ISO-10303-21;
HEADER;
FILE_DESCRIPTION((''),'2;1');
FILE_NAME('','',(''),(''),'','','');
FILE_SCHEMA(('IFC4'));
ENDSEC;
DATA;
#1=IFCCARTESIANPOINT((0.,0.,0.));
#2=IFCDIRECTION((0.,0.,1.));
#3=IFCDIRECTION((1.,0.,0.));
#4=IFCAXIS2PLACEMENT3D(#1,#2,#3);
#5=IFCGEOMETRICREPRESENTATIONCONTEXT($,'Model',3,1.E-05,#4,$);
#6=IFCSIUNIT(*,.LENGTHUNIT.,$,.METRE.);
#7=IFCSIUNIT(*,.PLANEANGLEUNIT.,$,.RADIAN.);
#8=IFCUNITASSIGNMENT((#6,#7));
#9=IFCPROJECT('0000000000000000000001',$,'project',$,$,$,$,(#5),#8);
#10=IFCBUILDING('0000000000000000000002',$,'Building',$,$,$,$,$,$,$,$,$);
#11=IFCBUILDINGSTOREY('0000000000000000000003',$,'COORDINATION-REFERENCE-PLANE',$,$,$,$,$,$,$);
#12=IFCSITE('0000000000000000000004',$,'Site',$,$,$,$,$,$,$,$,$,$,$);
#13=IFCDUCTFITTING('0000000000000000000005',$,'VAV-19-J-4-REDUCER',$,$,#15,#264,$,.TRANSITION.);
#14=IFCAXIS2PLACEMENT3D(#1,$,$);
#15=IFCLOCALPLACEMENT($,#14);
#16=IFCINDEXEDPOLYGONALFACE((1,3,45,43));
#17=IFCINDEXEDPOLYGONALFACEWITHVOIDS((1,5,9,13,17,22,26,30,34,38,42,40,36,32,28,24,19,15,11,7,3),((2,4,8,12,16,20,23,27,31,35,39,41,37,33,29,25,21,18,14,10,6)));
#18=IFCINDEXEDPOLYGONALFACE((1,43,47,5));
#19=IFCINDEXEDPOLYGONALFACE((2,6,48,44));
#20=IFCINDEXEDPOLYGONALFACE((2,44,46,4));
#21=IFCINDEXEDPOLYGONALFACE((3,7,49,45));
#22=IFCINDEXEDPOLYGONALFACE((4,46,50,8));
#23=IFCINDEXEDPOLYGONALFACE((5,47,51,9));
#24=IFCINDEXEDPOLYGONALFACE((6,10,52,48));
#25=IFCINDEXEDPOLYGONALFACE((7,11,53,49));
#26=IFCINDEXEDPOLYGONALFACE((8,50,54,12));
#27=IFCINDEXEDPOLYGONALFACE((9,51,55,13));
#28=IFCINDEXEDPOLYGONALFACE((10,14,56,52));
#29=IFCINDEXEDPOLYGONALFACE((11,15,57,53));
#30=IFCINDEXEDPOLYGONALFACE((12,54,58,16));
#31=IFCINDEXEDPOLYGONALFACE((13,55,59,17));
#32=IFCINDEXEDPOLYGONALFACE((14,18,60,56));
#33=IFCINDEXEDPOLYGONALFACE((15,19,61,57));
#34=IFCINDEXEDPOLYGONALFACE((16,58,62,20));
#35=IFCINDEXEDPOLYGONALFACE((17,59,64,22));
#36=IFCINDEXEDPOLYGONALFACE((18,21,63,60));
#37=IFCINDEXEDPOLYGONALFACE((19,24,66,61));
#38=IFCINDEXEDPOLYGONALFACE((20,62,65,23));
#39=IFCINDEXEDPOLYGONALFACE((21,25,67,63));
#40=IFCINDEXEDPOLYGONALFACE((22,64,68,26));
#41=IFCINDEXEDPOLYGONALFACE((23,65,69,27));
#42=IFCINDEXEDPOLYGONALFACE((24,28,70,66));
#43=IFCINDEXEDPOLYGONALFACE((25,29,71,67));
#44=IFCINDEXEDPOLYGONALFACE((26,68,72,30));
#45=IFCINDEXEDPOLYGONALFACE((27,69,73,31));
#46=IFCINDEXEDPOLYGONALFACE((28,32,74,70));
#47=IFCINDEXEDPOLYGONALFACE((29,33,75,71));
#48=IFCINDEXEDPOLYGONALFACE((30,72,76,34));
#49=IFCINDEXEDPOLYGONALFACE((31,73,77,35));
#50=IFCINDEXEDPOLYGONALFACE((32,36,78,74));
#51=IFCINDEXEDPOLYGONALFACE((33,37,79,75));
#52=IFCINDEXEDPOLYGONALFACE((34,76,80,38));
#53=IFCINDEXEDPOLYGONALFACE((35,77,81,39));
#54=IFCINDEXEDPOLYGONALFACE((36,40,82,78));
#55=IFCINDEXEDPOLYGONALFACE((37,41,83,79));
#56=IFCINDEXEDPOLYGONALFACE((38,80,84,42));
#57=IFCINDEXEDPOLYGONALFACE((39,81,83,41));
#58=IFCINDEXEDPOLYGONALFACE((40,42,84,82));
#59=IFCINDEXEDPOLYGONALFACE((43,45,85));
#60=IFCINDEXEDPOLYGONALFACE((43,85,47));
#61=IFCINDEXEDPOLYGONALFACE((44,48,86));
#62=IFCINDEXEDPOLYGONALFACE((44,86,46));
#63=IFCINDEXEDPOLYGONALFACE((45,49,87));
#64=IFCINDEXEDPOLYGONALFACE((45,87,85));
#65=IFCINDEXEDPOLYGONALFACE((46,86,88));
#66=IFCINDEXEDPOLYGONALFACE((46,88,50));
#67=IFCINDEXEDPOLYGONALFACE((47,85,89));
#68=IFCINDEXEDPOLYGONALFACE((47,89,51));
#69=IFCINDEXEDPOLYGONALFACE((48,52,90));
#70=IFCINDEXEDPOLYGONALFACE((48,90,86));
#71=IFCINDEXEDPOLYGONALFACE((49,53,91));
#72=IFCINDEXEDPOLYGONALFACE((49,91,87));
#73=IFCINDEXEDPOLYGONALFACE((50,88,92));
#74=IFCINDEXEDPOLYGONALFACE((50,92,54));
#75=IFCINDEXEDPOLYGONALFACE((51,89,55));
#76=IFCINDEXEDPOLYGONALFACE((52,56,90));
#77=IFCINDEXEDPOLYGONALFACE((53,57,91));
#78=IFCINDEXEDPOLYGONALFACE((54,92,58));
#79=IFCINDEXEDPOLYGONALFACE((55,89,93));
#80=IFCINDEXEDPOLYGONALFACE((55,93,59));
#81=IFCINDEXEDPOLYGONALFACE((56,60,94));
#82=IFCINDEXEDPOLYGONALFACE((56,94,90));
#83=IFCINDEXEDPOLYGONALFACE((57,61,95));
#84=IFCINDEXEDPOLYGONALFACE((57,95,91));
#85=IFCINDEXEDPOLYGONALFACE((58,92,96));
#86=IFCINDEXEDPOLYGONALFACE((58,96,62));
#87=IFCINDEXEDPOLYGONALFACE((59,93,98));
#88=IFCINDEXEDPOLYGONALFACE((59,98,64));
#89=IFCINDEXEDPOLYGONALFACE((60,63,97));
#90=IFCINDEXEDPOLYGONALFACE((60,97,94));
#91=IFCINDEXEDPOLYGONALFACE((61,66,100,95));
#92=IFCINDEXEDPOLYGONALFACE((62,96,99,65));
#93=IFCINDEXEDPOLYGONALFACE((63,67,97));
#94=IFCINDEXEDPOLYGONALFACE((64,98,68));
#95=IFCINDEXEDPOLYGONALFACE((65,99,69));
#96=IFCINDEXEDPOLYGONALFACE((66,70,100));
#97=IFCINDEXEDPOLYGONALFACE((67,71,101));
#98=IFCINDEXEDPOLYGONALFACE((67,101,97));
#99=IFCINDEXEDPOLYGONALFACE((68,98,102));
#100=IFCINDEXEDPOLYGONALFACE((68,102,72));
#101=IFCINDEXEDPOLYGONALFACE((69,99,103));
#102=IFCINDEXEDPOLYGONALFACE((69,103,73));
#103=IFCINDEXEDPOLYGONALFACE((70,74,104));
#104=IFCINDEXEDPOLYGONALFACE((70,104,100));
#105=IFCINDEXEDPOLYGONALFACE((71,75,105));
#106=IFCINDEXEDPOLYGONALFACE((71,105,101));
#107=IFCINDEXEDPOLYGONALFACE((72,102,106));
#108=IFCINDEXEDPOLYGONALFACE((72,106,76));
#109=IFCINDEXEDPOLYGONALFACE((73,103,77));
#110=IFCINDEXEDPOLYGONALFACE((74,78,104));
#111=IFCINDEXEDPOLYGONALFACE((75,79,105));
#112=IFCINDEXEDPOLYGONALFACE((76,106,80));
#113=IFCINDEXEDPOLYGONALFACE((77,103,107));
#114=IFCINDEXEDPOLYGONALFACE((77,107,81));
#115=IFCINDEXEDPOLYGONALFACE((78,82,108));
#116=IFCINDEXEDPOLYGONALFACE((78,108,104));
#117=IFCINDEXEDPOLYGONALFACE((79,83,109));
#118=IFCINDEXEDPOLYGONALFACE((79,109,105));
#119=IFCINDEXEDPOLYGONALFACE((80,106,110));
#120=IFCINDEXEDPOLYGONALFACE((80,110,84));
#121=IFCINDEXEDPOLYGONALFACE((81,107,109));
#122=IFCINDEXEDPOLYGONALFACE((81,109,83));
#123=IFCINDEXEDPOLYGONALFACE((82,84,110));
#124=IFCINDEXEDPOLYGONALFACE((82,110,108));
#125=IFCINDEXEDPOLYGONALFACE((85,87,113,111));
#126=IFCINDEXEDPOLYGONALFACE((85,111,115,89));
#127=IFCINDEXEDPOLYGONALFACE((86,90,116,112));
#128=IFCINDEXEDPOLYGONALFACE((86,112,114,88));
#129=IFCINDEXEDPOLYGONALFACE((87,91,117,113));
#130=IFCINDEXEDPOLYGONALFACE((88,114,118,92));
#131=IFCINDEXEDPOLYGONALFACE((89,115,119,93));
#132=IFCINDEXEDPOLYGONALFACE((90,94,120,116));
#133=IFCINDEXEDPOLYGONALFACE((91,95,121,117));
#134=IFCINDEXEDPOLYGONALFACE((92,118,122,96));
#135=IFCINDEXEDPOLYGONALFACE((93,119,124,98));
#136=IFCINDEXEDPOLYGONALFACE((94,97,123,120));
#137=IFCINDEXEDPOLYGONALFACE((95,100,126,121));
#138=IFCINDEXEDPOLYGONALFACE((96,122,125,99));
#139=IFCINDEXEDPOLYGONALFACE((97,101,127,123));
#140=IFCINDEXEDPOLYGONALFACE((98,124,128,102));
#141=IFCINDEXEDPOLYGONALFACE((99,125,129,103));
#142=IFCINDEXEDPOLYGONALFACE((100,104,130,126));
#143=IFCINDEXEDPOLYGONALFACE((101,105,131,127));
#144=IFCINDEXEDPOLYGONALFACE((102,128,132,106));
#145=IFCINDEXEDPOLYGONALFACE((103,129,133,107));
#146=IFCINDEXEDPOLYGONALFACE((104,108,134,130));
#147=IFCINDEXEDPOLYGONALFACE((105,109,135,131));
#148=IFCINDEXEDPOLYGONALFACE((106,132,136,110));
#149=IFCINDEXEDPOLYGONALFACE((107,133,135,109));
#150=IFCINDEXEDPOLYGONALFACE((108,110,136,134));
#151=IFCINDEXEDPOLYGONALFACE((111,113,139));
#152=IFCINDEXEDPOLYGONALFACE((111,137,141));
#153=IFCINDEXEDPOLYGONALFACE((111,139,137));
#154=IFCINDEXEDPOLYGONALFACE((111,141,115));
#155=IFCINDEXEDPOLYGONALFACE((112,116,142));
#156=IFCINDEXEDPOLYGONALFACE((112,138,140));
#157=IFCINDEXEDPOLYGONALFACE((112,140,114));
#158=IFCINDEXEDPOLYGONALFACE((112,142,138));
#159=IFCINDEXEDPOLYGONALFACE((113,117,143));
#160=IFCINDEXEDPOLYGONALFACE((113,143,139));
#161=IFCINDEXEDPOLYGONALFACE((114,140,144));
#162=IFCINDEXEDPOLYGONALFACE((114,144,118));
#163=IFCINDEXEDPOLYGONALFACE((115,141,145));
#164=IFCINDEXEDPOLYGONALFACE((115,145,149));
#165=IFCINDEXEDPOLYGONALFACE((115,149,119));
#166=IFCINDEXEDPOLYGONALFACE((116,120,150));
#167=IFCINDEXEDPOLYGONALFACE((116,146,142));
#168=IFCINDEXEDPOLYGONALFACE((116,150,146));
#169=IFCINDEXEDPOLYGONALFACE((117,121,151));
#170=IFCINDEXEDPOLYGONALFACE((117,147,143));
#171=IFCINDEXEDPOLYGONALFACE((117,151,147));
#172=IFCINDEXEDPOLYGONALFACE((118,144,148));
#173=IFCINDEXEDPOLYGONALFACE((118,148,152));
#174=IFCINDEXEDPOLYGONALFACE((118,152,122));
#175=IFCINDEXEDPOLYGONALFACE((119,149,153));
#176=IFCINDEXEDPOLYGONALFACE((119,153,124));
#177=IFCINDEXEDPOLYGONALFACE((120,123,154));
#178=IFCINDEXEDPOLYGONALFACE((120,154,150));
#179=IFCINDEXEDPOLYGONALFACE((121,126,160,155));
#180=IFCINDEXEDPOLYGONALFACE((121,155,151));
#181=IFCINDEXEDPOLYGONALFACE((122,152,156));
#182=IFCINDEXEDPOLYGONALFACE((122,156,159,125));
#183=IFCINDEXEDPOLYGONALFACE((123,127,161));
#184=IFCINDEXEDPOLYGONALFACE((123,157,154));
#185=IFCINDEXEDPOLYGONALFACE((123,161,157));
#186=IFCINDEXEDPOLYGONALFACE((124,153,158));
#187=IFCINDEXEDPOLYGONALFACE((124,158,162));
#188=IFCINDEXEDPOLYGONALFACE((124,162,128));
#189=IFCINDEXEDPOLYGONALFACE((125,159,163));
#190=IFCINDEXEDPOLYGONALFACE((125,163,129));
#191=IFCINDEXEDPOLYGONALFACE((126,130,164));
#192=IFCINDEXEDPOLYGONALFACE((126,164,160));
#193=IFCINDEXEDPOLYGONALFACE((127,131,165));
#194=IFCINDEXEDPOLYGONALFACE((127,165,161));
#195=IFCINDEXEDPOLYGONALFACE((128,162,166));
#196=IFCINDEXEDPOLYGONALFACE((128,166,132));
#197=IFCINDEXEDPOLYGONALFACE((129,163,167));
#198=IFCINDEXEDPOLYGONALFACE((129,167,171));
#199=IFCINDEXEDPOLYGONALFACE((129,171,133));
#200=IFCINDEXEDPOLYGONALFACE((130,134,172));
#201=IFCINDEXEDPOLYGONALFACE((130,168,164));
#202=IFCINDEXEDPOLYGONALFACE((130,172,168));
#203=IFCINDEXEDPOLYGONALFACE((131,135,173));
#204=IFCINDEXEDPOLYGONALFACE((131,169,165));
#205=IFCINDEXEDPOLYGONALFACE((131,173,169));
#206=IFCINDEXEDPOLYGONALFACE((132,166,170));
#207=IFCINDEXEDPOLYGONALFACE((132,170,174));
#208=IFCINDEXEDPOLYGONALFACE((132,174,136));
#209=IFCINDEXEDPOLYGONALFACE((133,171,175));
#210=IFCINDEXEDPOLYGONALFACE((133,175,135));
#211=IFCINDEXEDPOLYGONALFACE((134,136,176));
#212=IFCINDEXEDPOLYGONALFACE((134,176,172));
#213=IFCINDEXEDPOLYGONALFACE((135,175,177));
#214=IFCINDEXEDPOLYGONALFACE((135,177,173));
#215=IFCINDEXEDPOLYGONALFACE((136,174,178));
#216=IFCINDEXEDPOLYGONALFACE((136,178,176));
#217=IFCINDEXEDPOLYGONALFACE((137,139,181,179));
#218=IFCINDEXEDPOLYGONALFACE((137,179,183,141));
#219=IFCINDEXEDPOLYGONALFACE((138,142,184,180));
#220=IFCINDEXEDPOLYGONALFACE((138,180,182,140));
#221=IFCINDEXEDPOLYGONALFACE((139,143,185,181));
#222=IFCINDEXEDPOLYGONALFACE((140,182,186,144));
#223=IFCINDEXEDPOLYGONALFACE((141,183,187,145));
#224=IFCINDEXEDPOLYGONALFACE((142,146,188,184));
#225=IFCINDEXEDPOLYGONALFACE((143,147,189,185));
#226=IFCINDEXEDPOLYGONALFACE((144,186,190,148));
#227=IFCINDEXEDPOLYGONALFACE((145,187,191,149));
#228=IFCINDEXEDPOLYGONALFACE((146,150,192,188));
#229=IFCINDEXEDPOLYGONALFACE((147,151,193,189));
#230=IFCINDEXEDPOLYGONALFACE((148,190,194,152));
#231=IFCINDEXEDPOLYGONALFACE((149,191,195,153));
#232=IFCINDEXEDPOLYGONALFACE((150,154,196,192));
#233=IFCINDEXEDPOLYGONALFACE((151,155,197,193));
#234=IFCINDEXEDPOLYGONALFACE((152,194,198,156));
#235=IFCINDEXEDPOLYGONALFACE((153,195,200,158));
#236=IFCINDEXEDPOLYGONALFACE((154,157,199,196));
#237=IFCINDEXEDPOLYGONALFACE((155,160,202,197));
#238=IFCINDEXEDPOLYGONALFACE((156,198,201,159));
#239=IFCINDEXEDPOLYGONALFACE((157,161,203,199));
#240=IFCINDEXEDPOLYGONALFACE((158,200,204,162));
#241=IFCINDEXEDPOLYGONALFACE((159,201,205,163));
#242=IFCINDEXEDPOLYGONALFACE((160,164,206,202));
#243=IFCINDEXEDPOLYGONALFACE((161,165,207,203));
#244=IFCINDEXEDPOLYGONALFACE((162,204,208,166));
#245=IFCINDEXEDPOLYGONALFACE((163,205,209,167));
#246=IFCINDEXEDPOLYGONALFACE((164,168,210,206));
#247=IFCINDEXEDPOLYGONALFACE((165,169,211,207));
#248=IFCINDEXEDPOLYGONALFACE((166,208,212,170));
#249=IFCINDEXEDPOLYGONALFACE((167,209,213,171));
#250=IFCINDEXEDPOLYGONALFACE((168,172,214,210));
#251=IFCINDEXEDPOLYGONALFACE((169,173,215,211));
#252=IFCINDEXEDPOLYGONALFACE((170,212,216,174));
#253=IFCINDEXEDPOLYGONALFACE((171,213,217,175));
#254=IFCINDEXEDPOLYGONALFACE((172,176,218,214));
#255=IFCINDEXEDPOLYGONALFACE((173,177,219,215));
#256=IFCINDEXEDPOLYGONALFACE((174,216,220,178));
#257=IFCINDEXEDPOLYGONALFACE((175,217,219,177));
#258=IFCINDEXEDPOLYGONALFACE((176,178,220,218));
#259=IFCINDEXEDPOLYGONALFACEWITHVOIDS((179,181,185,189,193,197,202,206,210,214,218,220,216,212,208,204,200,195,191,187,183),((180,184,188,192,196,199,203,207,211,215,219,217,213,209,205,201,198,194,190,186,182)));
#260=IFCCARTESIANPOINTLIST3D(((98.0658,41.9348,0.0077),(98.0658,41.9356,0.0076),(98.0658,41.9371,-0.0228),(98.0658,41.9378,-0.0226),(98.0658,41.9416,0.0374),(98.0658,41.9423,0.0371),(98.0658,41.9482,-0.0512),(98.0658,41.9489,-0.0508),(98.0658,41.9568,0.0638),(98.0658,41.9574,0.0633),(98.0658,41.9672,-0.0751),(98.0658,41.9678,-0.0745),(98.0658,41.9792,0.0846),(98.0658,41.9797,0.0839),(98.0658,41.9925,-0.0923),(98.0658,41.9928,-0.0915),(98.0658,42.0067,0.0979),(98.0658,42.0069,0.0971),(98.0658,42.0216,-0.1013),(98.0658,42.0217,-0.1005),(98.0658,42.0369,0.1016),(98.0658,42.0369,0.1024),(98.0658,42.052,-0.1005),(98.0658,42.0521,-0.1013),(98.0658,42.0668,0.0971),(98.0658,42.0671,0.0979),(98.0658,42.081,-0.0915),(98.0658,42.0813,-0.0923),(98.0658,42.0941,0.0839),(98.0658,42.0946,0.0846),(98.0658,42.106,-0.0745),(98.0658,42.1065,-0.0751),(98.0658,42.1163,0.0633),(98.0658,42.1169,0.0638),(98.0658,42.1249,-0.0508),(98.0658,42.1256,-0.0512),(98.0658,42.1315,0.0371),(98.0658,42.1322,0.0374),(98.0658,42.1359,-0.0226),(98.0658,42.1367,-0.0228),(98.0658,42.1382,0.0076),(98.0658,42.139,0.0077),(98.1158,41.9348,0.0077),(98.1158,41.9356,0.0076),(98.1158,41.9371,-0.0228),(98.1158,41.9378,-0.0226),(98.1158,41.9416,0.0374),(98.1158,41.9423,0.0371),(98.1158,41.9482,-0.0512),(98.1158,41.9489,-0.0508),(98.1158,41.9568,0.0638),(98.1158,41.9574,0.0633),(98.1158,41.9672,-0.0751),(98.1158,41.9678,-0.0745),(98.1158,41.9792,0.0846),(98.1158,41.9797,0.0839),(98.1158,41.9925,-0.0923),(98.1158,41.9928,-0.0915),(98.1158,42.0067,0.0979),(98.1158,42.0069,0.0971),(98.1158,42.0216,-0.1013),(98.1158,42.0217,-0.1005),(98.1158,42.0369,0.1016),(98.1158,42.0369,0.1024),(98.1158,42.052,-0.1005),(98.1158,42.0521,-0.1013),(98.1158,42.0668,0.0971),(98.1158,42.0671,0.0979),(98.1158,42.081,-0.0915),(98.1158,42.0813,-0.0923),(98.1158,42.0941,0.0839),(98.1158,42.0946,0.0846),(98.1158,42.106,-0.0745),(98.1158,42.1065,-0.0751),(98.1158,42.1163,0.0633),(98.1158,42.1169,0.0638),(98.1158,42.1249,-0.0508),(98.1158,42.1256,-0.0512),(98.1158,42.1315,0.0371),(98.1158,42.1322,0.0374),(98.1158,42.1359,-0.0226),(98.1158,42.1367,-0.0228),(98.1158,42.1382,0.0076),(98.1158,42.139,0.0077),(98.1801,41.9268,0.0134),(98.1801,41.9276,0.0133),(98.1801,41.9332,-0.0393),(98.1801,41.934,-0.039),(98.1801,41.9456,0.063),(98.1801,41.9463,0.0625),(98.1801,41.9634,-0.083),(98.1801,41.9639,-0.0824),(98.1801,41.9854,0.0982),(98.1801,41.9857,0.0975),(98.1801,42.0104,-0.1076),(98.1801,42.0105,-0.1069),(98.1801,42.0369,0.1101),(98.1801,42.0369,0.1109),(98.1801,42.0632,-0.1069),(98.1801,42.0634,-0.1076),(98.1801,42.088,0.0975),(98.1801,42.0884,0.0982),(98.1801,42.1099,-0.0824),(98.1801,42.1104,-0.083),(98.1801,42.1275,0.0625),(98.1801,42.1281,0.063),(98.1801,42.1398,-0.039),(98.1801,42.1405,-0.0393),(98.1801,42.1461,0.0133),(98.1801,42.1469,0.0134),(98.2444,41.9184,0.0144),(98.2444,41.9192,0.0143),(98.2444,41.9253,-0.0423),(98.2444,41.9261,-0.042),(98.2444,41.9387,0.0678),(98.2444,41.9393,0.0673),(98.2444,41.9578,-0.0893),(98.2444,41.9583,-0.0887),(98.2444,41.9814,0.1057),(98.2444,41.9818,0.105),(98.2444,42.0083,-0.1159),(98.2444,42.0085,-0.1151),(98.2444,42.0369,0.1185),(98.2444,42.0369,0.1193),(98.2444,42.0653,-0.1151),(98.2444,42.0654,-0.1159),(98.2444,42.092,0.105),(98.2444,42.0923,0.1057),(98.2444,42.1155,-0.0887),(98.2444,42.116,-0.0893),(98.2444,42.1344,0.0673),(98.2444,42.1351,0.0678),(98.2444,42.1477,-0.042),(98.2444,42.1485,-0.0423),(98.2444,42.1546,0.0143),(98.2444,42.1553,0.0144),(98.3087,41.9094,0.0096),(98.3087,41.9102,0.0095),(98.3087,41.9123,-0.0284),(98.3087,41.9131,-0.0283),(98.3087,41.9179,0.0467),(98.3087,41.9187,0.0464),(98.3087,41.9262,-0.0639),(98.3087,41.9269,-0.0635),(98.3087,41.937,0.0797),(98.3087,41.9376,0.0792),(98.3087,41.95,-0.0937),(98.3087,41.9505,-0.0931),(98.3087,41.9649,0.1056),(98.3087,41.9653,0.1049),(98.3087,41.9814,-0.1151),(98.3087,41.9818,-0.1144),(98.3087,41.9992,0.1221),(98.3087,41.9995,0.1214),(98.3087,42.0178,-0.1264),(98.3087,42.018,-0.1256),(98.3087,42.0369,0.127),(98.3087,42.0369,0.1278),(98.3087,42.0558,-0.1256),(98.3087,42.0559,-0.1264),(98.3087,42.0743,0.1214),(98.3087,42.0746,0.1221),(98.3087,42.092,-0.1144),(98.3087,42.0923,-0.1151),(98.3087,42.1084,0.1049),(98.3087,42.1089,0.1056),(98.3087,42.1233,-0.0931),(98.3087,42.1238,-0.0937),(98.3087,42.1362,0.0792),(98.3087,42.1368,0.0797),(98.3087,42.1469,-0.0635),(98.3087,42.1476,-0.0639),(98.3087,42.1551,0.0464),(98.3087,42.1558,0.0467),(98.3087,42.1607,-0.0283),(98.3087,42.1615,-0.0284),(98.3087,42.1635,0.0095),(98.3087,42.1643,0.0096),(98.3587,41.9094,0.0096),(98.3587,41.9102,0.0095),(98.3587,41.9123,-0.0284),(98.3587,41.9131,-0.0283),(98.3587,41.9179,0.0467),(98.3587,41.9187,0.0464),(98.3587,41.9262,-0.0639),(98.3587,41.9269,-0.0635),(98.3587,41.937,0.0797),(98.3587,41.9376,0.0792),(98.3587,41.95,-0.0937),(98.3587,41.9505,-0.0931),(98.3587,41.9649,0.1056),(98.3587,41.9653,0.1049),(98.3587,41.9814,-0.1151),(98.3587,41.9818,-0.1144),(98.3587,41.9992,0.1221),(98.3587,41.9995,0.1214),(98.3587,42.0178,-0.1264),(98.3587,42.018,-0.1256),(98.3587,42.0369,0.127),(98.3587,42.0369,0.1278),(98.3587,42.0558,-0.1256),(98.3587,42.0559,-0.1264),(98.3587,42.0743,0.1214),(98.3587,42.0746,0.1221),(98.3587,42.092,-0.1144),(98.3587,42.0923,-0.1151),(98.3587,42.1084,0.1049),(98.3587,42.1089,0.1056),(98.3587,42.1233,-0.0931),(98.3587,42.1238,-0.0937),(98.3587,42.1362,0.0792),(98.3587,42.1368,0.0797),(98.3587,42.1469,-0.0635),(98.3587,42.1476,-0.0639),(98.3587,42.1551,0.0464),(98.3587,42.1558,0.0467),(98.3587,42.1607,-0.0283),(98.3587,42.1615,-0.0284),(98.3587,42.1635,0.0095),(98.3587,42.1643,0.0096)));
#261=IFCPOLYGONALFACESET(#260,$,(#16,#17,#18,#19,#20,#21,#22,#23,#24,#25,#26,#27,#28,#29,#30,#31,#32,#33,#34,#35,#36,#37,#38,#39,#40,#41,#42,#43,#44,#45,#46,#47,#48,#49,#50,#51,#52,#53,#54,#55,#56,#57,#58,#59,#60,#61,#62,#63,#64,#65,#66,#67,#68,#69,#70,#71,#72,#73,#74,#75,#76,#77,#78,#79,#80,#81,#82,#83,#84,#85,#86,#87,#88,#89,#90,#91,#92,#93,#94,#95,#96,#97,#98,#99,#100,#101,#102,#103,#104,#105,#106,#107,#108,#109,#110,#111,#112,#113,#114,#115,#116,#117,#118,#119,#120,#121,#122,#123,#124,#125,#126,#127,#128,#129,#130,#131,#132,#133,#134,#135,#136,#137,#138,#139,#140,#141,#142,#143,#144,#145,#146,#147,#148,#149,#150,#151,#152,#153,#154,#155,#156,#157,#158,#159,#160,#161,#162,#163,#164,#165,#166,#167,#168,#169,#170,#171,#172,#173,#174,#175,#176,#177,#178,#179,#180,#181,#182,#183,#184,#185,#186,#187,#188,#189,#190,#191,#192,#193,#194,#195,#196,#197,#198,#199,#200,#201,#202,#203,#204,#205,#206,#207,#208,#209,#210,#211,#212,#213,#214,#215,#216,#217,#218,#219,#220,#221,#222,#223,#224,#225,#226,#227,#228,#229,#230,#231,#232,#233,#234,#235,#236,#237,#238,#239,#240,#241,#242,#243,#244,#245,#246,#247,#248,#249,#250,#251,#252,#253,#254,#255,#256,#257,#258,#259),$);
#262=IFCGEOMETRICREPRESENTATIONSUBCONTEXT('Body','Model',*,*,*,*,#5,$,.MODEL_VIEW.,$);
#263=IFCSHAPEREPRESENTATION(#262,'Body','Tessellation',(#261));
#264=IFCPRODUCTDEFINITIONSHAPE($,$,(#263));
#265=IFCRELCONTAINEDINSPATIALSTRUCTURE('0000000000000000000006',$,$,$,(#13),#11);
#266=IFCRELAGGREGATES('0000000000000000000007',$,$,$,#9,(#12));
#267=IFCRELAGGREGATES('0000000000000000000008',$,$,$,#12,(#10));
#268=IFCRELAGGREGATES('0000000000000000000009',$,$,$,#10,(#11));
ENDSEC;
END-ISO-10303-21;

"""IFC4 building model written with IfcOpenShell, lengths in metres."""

from ifc_helpers import new_model, entity, si_unit, frame, origin_with_axes, place, context, subcontext, project, spatial, element, save


model = new_model("IFC4")

# Units and contexts
model_context_1 = context("Model", 3, precision=1e-05, world=origin_with_axes())
body_context_1 = subcontext(model_context_1, "Body", "Model", "MODEL_VIEW")
ifc_project = project(units=[si_unit("LENGTHUNIT", "METRE"), si_unit("PLANEANGLEUNIT", "RADIAN")], contexts=[model_context_1])

# Site, building, storey
site = spatial("IfcSite", under=ifc_project, Name="Site")
building = spatial("IfcBuilding", under=site, Name="Building")
storey = spatial("IfcBuildingStorey", under=building, Name="COORDINATION-REFERENCE-PLANE")

# Duct fitting
for number, where, z_axis, x_axis, name in (
    (1, (98.3587, 42.0369, 0.0), (0.0, -1.0, 0.0), (0.0, 0.0, 1.0), "VAV-19-J-4-REDUCER"),
):
    element("IfcDuctFitting", number, at=place(None, frame(where, z_axis=z_axis, x_axis=x_axis)), inside=storey, Name=name, PredefinedType="TRANSITION", context=body_context_1, shape_type="SweptSolid", body=[
        entity("IfcRevolvedAreaSolid", entity("IfcArbitraryClosedProfileDef", "AREA", None, entity("IfcPolyline", [entity("IfcCartesianPoint", [0.1278, 0.0]), entity("IfcCartesianPoint", [0.1278, 0.05]), entity("IfcCartesianPoint", [0.1024, 0.2429]), entity("IfcCartesianPoint", [0.1024, 0.2929]), entity("IfcCartesianPoint", [0.1016, 0.2929]), entity("IfcCartesianPoint", [0.1016, 0.2429]), entity("IfcCartesianPoint", [0.127, 0.05]), entity("IfcCartesianPoint", [0.127, 0.0]), entity("IfcCartesianPoint", [0.1278, 0.0])])), entity("IfcAxis2Placement3D", entity("IfcCartesianPoint", [0.0, 0.0, 0.0])), entity("IfcAxis1Placement", entity("IfcCartesianPoint", [0.0, 0.0, 0.0]), entity("IfcDirection", [0.0, 1.0, 0.0])), 6.283185),
    ])

save(model, "model.ifc")
